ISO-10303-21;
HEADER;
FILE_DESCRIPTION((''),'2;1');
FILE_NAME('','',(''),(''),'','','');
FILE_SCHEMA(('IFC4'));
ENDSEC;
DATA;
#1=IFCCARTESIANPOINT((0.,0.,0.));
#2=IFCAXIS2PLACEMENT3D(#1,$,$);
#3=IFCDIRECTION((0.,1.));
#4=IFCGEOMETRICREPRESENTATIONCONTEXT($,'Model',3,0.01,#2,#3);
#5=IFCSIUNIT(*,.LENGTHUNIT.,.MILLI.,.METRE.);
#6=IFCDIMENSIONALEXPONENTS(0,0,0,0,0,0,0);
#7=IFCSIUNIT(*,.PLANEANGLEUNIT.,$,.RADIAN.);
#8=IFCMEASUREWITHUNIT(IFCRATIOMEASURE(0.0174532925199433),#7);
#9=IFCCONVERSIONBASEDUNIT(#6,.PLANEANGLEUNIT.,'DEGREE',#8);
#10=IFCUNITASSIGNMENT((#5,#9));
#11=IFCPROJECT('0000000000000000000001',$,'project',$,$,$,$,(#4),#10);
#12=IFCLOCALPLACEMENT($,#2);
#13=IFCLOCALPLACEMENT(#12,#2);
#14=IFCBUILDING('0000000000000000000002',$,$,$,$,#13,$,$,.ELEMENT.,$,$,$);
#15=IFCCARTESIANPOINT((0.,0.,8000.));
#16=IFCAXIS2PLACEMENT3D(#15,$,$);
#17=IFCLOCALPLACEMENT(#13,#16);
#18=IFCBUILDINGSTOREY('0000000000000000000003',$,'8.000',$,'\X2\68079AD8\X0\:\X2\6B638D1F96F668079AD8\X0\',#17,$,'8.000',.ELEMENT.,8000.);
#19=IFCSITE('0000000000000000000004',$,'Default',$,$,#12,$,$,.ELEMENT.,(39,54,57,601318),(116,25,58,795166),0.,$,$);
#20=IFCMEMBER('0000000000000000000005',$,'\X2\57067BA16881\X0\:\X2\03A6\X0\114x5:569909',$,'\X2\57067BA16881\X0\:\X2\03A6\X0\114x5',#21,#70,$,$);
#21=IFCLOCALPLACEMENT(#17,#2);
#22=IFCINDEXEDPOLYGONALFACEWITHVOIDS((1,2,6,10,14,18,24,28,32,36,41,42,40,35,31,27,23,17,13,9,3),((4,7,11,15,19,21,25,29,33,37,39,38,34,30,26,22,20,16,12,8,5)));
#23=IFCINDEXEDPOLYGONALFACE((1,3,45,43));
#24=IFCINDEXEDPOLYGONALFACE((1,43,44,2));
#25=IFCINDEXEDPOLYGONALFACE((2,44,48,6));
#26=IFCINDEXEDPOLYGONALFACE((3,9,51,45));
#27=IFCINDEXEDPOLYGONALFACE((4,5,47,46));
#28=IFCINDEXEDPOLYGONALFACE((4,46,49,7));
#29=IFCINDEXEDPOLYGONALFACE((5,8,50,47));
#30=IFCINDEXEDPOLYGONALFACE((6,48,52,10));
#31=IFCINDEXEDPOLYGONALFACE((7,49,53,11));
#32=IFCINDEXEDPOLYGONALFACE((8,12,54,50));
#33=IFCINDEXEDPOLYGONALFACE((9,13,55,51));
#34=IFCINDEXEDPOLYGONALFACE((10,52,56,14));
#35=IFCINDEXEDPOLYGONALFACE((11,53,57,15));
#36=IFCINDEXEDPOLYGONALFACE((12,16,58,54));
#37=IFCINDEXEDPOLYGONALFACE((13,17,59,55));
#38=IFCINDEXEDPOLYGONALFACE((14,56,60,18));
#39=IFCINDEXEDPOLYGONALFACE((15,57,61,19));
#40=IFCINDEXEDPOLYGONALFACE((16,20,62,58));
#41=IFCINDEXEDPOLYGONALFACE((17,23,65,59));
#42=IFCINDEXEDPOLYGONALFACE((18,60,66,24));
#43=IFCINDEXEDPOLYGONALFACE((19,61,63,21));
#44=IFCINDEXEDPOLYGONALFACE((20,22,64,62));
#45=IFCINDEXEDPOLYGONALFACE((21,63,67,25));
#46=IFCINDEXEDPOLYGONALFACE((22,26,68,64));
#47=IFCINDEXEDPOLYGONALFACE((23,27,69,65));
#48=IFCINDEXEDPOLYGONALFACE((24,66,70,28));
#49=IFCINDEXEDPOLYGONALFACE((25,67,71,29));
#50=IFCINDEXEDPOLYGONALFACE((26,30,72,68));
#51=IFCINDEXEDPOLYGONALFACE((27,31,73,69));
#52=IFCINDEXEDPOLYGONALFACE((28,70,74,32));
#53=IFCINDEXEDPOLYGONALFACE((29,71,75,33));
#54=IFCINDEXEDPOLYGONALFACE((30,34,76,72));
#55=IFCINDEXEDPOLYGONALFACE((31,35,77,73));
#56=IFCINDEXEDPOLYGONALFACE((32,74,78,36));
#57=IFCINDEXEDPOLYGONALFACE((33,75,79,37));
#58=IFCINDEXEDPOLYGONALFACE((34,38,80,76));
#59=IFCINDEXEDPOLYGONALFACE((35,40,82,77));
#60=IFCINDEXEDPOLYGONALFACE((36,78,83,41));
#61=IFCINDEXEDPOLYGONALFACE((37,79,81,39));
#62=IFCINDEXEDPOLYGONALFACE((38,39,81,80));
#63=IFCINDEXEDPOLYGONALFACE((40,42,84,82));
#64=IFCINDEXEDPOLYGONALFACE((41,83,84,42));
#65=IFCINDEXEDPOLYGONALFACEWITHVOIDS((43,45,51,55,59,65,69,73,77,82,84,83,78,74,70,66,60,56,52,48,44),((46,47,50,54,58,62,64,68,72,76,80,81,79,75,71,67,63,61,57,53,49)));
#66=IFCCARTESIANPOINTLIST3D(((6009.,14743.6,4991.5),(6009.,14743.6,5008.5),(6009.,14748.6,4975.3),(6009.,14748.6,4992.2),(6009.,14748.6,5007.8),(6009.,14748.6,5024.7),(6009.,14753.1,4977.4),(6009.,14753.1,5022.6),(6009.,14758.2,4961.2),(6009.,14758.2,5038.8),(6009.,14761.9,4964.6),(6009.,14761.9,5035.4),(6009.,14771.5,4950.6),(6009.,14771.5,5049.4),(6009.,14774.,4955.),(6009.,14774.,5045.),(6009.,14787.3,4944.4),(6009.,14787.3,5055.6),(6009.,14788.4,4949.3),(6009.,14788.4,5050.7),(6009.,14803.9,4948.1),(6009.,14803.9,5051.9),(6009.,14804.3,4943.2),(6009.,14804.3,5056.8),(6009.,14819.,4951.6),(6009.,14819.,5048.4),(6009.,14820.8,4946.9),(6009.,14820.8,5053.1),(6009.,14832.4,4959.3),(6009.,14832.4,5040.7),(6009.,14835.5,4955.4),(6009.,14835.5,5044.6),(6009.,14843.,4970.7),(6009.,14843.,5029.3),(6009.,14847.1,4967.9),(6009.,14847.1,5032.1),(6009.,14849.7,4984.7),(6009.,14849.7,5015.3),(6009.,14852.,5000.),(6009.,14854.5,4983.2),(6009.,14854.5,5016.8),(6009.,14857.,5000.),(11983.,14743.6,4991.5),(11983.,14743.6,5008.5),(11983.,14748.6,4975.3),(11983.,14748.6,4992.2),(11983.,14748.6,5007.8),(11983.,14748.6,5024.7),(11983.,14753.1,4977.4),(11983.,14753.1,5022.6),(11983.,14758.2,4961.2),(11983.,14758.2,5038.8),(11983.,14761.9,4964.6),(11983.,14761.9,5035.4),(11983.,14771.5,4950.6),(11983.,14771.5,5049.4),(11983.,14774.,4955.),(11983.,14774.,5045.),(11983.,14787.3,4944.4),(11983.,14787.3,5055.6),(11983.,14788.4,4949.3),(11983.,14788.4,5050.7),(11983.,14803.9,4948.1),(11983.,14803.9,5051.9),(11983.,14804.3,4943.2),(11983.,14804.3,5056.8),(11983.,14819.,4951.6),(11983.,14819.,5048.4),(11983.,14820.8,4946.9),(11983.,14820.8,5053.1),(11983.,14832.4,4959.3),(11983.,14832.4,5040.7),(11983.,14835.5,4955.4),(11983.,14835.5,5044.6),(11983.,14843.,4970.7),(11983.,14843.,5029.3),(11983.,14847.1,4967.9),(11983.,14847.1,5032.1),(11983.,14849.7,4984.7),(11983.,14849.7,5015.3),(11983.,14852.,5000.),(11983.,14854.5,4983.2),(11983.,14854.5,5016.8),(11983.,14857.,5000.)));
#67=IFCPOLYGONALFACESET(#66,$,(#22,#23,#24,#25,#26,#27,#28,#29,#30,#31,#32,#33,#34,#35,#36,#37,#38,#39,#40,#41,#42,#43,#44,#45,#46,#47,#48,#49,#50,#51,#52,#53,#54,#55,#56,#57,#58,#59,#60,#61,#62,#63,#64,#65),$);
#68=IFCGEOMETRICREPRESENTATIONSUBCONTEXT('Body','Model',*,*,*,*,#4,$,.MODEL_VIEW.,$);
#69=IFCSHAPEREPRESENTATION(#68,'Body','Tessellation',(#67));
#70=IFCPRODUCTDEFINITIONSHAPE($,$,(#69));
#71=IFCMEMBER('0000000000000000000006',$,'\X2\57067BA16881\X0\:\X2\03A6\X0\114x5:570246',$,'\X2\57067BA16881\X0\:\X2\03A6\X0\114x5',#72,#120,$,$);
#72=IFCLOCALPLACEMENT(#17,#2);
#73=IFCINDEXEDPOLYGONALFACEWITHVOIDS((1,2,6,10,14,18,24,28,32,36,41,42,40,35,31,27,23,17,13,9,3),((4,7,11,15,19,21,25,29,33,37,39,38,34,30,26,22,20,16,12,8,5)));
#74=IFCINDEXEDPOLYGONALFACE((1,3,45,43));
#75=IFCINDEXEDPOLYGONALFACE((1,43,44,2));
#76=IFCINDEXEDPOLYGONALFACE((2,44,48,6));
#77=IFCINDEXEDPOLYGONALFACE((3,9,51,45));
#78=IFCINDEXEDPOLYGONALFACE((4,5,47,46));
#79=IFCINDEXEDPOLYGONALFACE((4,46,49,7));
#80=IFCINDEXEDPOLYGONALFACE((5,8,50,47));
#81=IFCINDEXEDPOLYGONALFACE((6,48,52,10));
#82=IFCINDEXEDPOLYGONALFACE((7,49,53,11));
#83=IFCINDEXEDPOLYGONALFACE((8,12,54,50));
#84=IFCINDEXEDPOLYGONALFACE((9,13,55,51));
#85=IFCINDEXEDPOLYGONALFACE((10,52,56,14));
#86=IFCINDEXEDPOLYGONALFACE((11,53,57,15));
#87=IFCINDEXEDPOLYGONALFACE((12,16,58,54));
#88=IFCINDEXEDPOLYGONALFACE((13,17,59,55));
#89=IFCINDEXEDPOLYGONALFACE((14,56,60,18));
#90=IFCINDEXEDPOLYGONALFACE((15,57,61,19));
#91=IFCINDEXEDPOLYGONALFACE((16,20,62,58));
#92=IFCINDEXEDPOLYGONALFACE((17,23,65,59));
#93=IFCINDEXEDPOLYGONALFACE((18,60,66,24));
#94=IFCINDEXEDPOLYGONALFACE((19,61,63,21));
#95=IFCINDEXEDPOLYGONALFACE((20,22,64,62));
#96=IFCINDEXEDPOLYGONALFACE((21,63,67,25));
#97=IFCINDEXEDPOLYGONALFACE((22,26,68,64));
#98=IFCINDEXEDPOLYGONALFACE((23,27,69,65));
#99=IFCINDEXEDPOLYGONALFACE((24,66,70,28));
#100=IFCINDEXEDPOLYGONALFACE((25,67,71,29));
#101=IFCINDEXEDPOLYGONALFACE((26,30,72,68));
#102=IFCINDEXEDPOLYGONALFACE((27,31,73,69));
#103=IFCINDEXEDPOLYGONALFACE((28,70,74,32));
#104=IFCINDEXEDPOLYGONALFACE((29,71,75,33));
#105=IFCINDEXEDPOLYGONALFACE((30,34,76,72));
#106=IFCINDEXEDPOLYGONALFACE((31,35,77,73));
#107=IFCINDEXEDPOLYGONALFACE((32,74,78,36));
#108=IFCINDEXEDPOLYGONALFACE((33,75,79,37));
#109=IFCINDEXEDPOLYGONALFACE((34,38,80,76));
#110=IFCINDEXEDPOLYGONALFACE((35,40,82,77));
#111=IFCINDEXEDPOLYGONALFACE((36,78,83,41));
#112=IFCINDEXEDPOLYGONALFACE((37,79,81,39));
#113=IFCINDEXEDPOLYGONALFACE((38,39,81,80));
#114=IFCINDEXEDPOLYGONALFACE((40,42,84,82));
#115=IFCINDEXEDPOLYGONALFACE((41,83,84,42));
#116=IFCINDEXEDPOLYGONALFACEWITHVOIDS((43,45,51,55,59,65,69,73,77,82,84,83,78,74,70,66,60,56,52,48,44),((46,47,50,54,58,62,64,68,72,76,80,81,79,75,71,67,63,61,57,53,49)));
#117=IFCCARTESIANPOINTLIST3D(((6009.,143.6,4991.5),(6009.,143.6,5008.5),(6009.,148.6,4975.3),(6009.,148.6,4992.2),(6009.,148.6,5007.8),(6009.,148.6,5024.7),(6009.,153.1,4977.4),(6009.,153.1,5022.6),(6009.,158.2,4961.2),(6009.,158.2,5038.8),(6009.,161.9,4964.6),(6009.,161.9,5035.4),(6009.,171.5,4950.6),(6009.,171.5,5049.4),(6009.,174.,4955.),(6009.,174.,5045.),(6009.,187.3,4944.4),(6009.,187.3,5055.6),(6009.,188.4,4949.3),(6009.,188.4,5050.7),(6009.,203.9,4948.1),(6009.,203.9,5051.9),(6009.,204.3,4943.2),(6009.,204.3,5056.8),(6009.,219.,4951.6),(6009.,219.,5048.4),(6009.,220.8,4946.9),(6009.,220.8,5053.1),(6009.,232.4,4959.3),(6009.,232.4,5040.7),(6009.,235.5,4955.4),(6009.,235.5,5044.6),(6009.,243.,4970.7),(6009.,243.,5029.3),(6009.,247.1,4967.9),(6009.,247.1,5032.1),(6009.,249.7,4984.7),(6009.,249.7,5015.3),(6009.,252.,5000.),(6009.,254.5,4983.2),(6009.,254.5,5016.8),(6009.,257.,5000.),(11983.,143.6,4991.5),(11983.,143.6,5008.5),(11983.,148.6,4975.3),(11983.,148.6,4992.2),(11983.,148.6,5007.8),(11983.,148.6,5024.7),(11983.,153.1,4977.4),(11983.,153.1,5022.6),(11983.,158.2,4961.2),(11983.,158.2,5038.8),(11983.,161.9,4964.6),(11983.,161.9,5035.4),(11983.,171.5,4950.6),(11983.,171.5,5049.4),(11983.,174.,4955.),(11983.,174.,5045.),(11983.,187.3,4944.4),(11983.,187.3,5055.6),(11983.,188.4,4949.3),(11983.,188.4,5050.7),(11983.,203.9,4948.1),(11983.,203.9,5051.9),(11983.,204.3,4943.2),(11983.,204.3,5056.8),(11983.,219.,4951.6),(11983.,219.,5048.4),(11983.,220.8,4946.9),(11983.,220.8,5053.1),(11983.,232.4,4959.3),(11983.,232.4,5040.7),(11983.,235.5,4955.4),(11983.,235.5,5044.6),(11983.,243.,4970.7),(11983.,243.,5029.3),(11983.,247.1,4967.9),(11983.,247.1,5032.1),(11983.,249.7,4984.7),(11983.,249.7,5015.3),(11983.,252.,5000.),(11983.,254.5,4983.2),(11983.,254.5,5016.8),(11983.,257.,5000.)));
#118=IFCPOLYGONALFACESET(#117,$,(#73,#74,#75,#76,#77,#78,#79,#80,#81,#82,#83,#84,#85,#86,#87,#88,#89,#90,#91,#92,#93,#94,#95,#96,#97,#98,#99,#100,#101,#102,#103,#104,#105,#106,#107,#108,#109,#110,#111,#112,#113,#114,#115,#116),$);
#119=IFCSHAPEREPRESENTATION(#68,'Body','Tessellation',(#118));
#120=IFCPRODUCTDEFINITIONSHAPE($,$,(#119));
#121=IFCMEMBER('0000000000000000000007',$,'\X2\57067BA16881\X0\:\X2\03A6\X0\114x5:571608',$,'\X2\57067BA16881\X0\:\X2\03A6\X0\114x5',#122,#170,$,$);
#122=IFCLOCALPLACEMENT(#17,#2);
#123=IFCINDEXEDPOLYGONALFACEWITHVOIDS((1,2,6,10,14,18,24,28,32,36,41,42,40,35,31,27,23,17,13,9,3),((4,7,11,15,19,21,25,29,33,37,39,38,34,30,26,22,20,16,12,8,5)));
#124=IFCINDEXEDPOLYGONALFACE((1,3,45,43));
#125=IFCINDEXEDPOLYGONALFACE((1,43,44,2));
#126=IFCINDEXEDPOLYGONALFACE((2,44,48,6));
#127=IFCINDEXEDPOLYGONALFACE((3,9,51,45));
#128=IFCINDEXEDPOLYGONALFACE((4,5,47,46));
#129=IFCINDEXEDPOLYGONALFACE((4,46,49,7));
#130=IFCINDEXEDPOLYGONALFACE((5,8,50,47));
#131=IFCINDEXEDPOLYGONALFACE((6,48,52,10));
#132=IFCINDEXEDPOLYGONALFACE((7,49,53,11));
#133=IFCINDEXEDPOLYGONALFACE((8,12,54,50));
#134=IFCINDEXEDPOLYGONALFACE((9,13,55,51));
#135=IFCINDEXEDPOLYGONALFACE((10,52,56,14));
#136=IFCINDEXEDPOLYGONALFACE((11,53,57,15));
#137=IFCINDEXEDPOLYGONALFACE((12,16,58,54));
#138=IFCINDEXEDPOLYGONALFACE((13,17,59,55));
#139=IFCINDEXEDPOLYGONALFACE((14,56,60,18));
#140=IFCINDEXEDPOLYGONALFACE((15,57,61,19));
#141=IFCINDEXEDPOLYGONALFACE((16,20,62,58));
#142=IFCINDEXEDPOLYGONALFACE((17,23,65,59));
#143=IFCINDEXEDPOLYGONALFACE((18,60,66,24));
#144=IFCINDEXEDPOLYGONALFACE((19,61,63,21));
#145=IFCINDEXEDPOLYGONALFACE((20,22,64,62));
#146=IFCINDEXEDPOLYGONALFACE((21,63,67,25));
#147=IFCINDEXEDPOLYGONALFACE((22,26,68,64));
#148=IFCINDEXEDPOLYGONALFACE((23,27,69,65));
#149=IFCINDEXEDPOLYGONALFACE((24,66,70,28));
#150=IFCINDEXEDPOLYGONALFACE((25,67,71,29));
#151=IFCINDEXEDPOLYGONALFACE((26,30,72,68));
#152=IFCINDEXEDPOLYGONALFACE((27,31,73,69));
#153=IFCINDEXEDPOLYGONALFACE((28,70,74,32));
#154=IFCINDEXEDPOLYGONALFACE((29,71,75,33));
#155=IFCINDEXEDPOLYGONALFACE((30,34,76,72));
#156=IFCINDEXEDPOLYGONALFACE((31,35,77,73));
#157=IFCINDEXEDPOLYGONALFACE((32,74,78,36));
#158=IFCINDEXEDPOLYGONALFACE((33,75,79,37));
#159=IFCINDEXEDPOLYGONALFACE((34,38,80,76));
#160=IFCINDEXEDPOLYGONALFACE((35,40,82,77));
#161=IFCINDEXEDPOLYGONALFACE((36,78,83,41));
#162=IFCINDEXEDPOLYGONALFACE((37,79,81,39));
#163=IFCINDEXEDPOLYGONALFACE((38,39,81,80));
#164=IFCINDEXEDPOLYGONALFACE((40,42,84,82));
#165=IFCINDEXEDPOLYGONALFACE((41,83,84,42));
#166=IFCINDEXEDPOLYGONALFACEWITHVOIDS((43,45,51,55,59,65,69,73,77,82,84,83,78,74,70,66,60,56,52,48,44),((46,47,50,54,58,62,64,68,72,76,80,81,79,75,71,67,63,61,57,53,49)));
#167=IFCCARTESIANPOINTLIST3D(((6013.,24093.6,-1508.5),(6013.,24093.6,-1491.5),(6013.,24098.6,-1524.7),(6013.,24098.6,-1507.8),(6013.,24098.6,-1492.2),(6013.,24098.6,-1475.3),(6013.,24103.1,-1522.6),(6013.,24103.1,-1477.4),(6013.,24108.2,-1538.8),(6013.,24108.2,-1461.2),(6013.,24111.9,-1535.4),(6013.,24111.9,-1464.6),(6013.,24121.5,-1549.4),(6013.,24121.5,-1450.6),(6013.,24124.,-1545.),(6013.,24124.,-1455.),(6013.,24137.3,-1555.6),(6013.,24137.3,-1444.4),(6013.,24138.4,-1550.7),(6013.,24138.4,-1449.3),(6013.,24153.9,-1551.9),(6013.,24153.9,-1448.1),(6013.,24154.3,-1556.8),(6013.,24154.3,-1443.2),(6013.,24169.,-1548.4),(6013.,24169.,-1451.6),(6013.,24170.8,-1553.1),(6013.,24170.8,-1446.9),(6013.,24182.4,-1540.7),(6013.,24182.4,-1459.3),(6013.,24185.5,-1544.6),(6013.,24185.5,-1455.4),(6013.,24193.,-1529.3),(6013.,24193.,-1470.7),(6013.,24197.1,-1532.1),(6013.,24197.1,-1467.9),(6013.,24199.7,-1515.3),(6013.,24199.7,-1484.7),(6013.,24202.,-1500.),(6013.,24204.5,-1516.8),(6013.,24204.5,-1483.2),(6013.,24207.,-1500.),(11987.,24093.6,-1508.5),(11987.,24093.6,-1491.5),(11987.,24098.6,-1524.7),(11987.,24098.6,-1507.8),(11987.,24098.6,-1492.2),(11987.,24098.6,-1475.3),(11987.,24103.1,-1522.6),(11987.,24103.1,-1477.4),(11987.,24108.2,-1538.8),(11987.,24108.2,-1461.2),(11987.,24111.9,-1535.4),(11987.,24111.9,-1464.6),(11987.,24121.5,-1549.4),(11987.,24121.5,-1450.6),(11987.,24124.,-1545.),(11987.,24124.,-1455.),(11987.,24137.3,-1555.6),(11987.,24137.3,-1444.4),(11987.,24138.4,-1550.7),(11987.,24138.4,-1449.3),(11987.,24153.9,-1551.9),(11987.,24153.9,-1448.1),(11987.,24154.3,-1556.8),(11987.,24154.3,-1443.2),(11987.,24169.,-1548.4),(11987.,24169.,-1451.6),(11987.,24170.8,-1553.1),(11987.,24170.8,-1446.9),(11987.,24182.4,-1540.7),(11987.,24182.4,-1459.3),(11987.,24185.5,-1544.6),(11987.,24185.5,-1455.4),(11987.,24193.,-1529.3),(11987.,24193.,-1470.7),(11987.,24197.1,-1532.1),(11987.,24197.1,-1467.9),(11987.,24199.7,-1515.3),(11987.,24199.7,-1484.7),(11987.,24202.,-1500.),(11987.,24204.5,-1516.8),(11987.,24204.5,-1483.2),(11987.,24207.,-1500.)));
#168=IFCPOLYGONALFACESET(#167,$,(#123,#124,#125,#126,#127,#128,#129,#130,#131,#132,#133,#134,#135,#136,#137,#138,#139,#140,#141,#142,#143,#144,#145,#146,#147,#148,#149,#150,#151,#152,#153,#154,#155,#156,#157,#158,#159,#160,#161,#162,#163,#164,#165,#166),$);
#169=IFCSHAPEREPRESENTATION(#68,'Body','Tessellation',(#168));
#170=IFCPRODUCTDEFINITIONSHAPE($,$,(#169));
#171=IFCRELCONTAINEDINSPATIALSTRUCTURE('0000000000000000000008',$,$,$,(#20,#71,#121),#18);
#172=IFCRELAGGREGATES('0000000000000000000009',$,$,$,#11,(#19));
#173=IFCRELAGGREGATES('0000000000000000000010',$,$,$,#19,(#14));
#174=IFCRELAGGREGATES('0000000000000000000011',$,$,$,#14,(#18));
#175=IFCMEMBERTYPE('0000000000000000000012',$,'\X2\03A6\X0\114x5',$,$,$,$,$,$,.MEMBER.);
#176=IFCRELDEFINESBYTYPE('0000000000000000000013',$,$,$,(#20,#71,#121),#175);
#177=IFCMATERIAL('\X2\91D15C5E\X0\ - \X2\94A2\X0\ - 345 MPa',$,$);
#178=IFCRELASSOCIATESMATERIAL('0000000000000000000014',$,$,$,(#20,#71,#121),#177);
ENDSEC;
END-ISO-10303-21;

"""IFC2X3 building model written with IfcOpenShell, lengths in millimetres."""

from ifc_helpers import new_model, entity, si_unit, converted_unit, direction, frame, frame_2d, origin, place, context, subcontext, project, spatial, hollow_circle, extrude, source, transform, mapped, material, type_object, type_shapes, element, save


model = new_model("IFC2X3")

# Units and contexts
model_context = context("Model", 3, precision=0.01, world=origin(), true_north=direction((0.0, 1.0)))
body_context = subcontext(model_context, "Body", "Model", "MODEL_VIEW")
ifc_project = project(units=[si_unit("LENGTHUNIT", "METRE", prefix="MILLI"), converted_unit("PLANEANGLEUNIT", "DEGREE", entity("IfcRatioMeasure", 0.0174532925199433), si_unit("PLANEANGLEUNIT", "RADIAN"), dimensions=[0, 0, 0, 0, 0, 0, 0])], contexts=[model_context])

# Site, building, storey
site_placement = place(None, origin())
site = spatial("IfcSite", under=ifc_project, at=site_placement, Name="Default", CompositionType="ELEMENT", RefLatitude=(39, 54, 57, 601318), RefLongitude=(116, 25, 58, 795166), RefElevation=0.0)
building_placement = place(site_placement, origin())
building = spatial("IfcBuilding", under=site, at=building_placement, CompositionType="ELEMENT")
storey_placement = place(building_placement, frame((0.0, 0.0, 8000.0)))
storey = spatial("IfcBuildingStorey", under=building, at=storey_placement, Name="8.000", ObjectType="标高:正负零标高", LongName="8.000", CompositionType="ELEMENT", Elevation=8000.0)

# Shared definitions
ifc_material_1 = material(Name="金属 - 钢 - 345 MPa")

# Members
member_type_1 = type_object("IfcMemberType", Name="Φ114x5", PredefinedType="MEMBER")
shared_shape_1 = source(origin(), body_context, "Body", "SweptSolid", [
    extrude(hollow_circle(Radius=57.0, WallThickness=5.0, at=frame_2d((0.0, 0.0), x_axis=(1.0, 0.0))), frame((-2987.0, 0.0, 0.0), z_axis=(1.0, 0.0, 0.0), x_axis=(0.0, 1.0, 0.0)), (0.0, 0.0, 1.0), 5974.0),
])
type_shapes(member_type_1, [shared_shape_1])
for number, where, name in (
    (1, (8996.0, 14800.0, 5000.0), "圆管梁:Φ114x5:569909"),
    (2, (8996.0, 200.0, 5000.0), "圆管梁:Φ114x5:570246"),
    (3, (9000.0, 24150.0, -1500.0), "圆管梁:Φ114x5:571608"),
):
    element("IfcMember", number, at=place(storey_placement, frame(where)), inside=storey, type_object=member_type_1, material=ifc_material_1, Name=name, ObjectType="圆管梁:Φ114x5", context=body_context, shape_type="MappedRepresentation", body=[
        mapped(shared_shape_1, transform((0.0, 0.0, 0.0), scale=1.0)),
    ])

save(model, "model.ifc")
